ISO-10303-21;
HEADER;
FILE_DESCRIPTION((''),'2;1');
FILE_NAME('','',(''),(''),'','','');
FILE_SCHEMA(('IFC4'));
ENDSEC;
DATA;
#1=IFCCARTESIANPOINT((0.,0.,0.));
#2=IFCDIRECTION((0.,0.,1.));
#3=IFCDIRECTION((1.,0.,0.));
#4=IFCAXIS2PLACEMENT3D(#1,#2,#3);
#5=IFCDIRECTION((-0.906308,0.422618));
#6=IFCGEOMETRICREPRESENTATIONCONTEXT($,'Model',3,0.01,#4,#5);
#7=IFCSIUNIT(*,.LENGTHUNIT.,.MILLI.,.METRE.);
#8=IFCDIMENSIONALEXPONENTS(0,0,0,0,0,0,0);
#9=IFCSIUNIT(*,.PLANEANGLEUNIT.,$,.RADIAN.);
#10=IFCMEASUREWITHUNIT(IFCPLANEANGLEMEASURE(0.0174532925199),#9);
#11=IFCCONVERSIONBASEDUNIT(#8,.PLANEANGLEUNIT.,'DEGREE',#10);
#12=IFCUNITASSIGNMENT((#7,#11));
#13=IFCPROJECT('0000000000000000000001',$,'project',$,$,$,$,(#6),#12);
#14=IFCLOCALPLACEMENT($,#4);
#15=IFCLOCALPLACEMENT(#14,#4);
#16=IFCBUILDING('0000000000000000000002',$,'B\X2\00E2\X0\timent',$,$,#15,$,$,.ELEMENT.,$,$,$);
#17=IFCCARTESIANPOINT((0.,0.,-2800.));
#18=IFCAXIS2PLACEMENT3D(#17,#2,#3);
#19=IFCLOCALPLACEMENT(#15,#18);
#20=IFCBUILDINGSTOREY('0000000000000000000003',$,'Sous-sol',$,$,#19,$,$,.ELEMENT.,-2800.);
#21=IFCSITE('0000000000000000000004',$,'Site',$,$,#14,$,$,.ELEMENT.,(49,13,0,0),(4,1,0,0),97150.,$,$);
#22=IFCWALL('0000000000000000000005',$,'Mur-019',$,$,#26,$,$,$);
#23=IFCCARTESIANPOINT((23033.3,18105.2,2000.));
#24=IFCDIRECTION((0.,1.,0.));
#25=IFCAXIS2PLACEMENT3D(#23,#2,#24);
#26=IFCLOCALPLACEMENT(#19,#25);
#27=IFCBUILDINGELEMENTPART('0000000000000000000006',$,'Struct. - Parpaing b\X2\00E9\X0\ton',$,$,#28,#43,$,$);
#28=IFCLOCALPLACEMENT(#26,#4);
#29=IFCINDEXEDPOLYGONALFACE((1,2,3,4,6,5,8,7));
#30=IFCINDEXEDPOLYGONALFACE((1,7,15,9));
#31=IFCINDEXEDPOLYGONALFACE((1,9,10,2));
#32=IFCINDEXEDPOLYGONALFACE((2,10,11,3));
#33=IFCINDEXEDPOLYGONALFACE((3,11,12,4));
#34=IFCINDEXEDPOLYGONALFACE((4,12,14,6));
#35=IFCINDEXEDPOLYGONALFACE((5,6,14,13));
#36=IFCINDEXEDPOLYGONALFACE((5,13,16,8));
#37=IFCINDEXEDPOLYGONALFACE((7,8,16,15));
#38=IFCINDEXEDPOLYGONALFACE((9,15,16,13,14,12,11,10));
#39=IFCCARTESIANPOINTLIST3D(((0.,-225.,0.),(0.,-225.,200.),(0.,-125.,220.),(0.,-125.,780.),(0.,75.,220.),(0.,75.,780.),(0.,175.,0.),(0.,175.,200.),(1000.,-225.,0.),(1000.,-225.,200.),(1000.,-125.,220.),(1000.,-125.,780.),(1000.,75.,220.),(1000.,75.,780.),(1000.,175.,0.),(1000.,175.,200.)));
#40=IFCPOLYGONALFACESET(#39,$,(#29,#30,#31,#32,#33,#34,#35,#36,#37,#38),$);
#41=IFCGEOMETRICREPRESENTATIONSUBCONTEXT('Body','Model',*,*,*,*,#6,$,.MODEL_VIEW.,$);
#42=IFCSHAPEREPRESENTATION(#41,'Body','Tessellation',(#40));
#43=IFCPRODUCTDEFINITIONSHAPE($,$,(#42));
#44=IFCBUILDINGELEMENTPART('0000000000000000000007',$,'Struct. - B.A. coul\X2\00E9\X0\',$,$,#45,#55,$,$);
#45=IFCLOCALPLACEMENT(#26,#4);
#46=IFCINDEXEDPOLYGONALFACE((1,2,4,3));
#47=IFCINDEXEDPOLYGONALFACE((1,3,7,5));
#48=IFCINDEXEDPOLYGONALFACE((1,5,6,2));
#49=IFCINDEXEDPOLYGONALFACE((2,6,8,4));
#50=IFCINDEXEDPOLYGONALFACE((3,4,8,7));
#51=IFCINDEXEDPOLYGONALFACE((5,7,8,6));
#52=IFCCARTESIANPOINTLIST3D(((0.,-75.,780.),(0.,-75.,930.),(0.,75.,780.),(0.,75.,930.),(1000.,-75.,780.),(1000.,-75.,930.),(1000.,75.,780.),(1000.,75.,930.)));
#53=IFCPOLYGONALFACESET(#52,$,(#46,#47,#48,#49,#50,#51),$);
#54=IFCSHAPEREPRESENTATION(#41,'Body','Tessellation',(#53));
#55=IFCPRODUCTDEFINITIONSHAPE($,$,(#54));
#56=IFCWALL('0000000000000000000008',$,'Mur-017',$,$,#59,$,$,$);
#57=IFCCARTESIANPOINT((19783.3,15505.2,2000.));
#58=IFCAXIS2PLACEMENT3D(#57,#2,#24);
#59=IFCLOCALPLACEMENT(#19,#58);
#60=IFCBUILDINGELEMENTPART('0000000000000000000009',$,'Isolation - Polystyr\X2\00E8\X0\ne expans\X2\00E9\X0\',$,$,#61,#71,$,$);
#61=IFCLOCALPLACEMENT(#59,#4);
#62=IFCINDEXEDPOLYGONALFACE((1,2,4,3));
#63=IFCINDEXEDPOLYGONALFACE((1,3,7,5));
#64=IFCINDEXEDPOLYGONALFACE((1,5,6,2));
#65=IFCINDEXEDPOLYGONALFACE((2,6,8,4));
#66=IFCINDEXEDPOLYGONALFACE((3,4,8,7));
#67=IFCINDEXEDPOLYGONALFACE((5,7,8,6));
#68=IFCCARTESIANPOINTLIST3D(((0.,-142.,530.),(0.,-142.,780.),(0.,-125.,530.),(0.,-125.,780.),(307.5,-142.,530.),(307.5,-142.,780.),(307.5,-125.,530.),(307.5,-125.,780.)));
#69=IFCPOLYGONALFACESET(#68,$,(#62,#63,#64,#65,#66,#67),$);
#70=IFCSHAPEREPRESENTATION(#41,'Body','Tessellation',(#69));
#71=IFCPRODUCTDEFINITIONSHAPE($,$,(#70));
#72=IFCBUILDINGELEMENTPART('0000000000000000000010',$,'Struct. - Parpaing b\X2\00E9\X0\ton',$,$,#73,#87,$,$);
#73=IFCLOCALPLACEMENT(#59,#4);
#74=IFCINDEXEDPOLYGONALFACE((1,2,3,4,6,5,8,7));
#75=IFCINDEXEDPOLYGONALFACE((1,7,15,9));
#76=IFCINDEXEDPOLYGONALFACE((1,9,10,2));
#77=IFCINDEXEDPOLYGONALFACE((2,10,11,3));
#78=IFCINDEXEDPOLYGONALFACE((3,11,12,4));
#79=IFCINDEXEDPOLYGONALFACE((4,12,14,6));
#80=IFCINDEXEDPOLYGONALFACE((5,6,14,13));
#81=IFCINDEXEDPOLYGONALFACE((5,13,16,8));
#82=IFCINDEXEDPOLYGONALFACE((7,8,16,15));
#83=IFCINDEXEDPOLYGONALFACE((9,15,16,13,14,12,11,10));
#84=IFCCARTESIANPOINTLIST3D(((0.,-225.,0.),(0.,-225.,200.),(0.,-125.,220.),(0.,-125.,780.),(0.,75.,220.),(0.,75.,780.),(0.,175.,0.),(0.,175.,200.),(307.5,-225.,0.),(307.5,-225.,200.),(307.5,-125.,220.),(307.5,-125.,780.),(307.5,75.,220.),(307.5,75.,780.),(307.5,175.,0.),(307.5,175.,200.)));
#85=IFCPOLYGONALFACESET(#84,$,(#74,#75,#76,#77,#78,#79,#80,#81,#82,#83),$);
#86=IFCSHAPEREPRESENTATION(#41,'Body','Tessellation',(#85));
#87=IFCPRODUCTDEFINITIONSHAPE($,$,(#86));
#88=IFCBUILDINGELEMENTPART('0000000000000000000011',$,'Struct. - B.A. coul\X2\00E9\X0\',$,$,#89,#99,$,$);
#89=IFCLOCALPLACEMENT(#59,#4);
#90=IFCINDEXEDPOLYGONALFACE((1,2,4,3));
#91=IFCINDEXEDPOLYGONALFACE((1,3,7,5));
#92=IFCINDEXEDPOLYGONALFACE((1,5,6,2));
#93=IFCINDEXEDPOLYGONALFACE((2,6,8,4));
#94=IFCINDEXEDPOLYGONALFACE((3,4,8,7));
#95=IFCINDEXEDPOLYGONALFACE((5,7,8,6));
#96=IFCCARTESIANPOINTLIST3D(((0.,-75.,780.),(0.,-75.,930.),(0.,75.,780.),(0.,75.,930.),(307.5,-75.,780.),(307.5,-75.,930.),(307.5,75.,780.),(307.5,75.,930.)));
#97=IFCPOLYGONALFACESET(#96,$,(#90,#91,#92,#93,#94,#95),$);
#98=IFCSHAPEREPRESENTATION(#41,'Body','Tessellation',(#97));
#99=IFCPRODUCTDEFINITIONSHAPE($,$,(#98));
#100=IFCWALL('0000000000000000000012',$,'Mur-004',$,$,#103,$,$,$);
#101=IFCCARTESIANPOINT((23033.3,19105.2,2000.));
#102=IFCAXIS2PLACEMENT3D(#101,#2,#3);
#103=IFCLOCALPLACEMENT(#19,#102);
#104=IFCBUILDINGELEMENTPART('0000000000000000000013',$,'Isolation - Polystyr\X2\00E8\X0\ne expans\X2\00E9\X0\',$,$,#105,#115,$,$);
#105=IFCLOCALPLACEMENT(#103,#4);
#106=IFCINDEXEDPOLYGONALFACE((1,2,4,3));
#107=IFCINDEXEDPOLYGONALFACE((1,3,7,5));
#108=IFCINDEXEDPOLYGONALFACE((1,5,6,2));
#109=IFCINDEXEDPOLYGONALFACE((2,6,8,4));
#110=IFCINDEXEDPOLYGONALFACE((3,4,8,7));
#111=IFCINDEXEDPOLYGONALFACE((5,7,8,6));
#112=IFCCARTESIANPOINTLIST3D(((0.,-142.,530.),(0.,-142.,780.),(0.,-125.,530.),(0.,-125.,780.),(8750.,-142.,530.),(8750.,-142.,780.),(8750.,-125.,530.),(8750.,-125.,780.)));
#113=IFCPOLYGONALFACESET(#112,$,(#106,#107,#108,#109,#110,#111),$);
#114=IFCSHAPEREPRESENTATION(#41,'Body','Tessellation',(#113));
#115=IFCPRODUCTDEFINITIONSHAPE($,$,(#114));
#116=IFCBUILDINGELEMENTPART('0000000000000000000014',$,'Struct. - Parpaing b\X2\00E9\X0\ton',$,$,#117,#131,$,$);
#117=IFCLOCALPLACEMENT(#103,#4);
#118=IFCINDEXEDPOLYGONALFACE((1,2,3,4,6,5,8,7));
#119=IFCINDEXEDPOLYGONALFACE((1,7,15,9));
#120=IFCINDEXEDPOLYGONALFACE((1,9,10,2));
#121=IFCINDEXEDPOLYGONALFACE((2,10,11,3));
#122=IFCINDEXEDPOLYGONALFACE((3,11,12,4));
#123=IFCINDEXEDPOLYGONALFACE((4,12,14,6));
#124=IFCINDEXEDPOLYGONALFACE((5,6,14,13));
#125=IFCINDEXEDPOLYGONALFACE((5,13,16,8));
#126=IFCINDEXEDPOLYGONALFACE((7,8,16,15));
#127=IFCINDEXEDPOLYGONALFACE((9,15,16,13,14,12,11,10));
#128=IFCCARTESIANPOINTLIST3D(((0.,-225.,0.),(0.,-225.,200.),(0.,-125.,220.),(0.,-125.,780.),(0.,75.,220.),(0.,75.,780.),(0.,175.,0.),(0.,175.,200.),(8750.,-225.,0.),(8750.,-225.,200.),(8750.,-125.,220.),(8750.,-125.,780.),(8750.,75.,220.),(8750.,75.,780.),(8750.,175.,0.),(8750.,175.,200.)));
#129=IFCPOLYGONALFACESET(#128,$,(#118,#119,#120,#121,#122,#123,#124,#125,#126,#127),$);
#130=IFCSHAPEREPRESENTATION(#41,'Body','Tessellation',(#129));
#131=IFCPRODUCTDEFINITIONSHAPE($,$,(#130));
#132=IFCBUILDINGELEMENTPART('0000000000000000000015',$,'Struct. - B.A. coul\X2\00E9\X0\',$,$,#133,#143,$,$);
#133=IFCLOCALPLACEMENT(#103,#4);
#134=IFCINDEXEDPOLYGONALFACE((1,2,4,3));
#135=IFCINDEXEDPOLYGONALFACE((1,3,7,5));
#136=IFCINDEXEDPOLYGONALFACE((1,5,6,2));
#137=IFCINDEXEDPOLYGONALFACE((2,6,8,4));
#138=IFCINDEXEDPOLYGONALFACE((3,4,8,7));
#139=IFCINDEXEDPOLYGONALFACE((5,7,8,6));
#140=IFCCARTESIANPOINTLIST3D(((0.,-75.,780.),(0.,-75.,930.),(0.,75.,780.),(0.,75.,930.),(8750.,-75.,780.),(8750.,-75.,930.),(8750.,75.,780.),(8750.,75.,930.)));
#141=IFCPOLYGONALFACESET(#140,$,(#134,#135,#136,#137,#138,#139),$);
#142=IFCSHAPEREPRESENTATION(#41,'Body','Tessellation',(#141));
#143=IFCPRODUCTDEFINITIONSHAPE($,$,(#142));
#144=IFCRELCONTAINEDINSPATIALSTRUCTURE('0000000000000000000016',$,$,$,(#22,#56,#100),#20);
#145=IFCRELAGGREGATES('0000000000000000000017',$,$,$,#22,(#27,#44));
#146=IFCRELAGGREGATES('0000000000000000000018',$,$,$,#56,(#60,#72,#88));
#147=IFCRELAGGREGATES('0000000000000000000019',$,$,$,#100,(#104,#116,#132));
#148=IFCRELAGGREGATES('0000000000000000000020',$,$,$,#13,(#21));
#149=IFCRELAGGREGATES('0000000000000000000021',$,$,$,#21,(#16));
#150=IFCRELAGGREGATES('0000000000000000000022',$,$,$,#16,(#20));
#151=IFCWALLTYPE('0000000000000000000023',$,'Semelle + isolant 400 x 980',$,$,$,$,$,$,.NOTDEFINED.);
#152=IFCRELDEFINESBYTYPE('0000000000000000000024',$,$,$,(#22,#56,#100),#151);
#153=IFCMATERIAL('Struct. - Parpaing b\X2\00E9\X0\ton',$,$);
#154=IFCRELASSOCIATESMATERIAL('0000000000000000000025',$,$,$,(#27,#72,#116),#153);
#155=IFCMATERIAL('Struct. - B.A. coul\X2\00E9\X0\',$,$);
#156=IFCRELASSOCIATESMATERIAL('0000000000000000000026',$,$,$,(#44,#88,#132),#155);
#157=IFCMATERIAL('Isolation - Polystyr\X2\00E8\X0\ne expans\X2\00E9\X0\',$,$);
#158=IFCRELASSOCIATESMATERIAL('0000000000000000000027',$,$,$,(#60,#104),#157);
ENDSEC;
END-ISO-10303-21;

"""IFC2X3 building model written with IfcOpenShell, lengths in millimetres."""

from ifc_helpers import new_model, entity, si_unit, converted_unit, direction, frame, origin_with_axes, place, context, subcontext, project, spatial, polyline, outline, extrude, material, type_object, element, aggregate, save


model = new_model("IFC2X3")

# Units and contexts
model_context = context("Model", 3, precision=0.01, world=origin_with_axes(), true_north=direction((-0.906308, 0.422618)))
body_context = subcontext(model_context, "Body", "Model", "MODEL_VIEW")
ifc_project = project(units=[si_unit("LENGTHUNIT", "METRE", prefix="MILLI"), converted_unit("PLANEANGLEUNIT", "DEGREE", entity("IfcPlaneAngleMeasure", 0.0174532925199), si_unit("PLANEANGLEUNIT", "RADIAN"), dimensions=[0, 0, 0, 0, 0, 0, 0])], contexts=[model_context])

# Site, building, storey
site_placement = place(None, origin_with_axes())
site = spatial("IfcSite", under=ifc_project, at=site_placement, Name="Site", CompositionType="ELEMENT", RefLatitude=(49, 13, 0, 0), RefLongitude=(4, 1, 0, 0), RefElevation=97150.0)
building_placement = place(site_placement, origin_with_axes())
building = spatial("IfcBuilding", under=site, at=building_placement, Name="Bâtiment", CompositionType="ELEMENT")
storey_placement = place(building_placement, frame((0.0, 0.0, -2800.0), z_axis=(0.0, 0.0, 1.0), x_axis=(1.0, 0.0, 0.0)))
storey = spatial("IfcBuildingStorey", under=building, at=storey_placement, Name="Sous-sol", CompositionType="ELEMENT", Elevation=-2800.0)

# Walls, building element parts
ifc_material_1 = material(Name="Isolation - Polystyrène expansé")
ifc_material_2 = material(Name="Struct. - Parpaing béton")
wall_type_1 = type_object("IfcWallType", Name="Semelle + isolant 400 x 980", PredefinedType="NOTDEFINED")
ifc_material_3 = material(Name="Struct. - B.A. coulé")
wall_1_placement = place(storey_placement, frame((23033.3, 18105.2, 2000.0), z_axis=(0.0, 0.0, 1.0), x_axis=(0.0, 1.0, 0.0)))
wall_1 = element("IfcWall", 1, at=wall_1_placement, inside=storey, type_object=wall_type_1, Name="Mur-019")
building_element_part_1_placement = place(wall_1_placement, origin_with_axes())
building_element_part_1 = element("IfcBuildingElementPart", 2, at=building_element_part_1_placement, material=ifc_material_2, Name="Struct. - Parpaing béton", context=body_context, shape_type="SweptSolid", body=[
    extrude(outline(polyline([(-75.0, 220.0), (-175.0, 200.0), (-175.0, 0.0), (225.0, 0.0), (225.0, 200.0), (125.0, 220.0), (125.0, 780.0), (-75.0, 780.0), (-75.0, 220.0)])), frame((0.0, 0.0, 0.0), z_axis=(-1.0, 0.0, 0.0), x_axis=(0.0, -1.0, 0.0)), (0.0, 0.0, -1.0), 1000.0),
])
building_element_part_2_placement = place(wall_1_placement, origin_with_axes())
building_element_part_2 = element("IfcBuildingElementPart", 3, at=building_element_part_2_placement, material=ifc_material_3, Name="Struct. - B.A. coulé", context=body_context, shape_type="SweptSolid", body=[
    extrude(outline(polyline([(75.0, 780.0), (75.0, 930.0), (-75.0, 930.0), (-75.0, 780.0), (75.0, 780.0)])), frame((0.0, 0.0, 0.0), z_axis=(-1.0, 0.0, 0.0), x_axis=(0.0, -1.0, 0.0)), (0.0, 0.0, -1.0), 1000.0),
])
aggregate(wall_1, [building_element_part_1, building_element_part_2])
wall_2_placement = place(storey_placement, frame((19783.3, 15505.2, 2000.0), z_axis=(0.0, 0.0, 1.0), x_axis=(0.0, 1.0, 0.0)))
wall_2 = element("IfcWall", 4, at=wall_2_placement, inside=storey, type_object=wall_type_1, Name="Mur-017")
building_element_part_3_placement = place(wall_2_placement, origin_with_axes())
building_element_part_3 = element("IfcBuildingElementPart", 5, at=building_element_part_3_placement, material=ifc_material_1, Name="Isolation - Polystyrène expansé", context=body_context, shape_type="SweptSolid", body=[
    extrude(outline(polyline([(125.0, 780.0), (125.0, 530.0), (142.0, 530.0), (142.0, 780.0), (125.0, 780.0)])), frame((0.0, 0.0, 0.0), z_axis=(-1.0, 0.0, 0.0), x_axis=(0.0, -1.0, 0.0)), (0.0, 0.0, -1.0), 307.5),
])
building_element_part_4_placement = place(wall_2_placement, origin_with_axes())
building_element_part_4 = element("IfcBuildingElementPart", 6, at=building_element_part_4_placement, material=ifc_material_2, Name="Struct. - Parpaing béton", context=body_context, shape_type="SweptSolid", body=[
    extrude(outline(polyline([(-75.0, 220.0), (-175.0, 200.0), (-175.0, 0.0), (225.0, 0.0), (225.0, 200.0), (125.0, 220.0), (125.0, 780.0), (-75.0, 780.0), (-75.0, 220.0)])), frame((0.0, 0.0, 0.0), z_axis=(-1.0, 0.0, 0.0), x_axis=(0.0, -1.0, 0.0)), (0.0, 0.0, -1.0), 307.5),
])
building_element_part_5_placement = place(wall_2_placement, origin_with_axes())
building_element_part_5 = element("IfcBuildingElementPart", 7, at=building_element_part_5_placement, material=ifc_material_3, Name="Struct. - B.A. coulé", context=body_context, shape_type="SweptSolid", body=[
    extrude(outline(polyline([(75.0, 780.0), (75.0, 930.0), (-75.0, 930.0), (-75.0, 780.0), (75.0, 780.0)])), frame((0.0, 0.0, 0.0), z_axis=(-1.0, 0.0, 0.0), x_axis=(0.0, -1.0, 0.0)), (0.0, 0.0, -1.0), 307.5),
])
aggregate(wall_2, [building_element_part_3, building_element_part_4, building_element_part_5])
wall_3_placement = place(storey_placement, frame((23033.3, 19105.2, 2000.0), z_axis=(0.0, 0.0, 1.0), x_axis=(1.0, 0.0, 0.0)))
wall_3 = element("IfcWall", 8, at=wall_3_placement, inside=storey, type_object=wall_type_1, Name="Mur-004")
building_element_part_6_placement = place(wall_3_placement, origin_with_axes())
building_element_part_6 = element("IfcBuildingElementPart", 9, at=building_element_part_6_placement, material=ifc_material_1, Name="Isolation - Polystyrène expansé", context=body_context, shape_type="SweptSolid", body=[
    extrude(outline(polyline([(125.0, 780.0), (125.0, 530.0), (142.0, 530.0), (142.0, 780.0), (125.0, 780.0)])), frame((0.0, 0.0, 0.0), z_axis=(-1.0, 0.0, 0.0), x_axis=(0.0, -1.0, 0.0)), (0.0, 0.0, -1.0), 8750.0),
])
building_element_part_7_placement = place(wall_3_placement, origin_with_axes())
building_element_part_7 = element("IfcBuildingElementPart", 10, at=building_element_part_7_placement, material=ifc_material_2, Name="Struct. - Parpaing béton", context=body_context, shape_type="SweptSolid", body=[
    extrude(outline(polyline([(-75.0, 220.0), (-175.0, 200.0), (-175.0, 0.0), (225.0, 0.0), (225.0, 200.0), (125.0, 220.0), (125.0, 780.0), (-75.0, 780.0), (-75.0, 220.0)])), frame((0.0, 0.0, 0.0), z_axis=(-1.0, 0.0, 0.0), x_axis=(0.0, -1.0, 0.0)), (0.0, 0.0, -1.0), 8750.0),
])
building_element_part_8_placement = place(wall_3_placement, origin_with_axes())
building_element_part_8 = element("IfcBuildingElementPart", 11, at=building_element_part_8_placement, material=ifc_material_3, Name="Struct. - B.A. coulé", context=body_context, shape_type="SweptSolid", body=[
    extrude(outline(polyline([(75.0, 780.0), (75.0, 930.0), (-75.0, 930.0), (-75.0, 780.0), (75.0, 780.0)])), frame((0.0, 0.0, 0.0), z_axis=(-1.0, 0.0, 0.0), x_axis=(0.0, -1.0, 0.0)), (0.0, 0.0, -1.0), 8750.0),
])
aggregate(wall_3, [building_element_part_6, building_element_part_7, building_element_part_8])

save(model, "model.ifc")
